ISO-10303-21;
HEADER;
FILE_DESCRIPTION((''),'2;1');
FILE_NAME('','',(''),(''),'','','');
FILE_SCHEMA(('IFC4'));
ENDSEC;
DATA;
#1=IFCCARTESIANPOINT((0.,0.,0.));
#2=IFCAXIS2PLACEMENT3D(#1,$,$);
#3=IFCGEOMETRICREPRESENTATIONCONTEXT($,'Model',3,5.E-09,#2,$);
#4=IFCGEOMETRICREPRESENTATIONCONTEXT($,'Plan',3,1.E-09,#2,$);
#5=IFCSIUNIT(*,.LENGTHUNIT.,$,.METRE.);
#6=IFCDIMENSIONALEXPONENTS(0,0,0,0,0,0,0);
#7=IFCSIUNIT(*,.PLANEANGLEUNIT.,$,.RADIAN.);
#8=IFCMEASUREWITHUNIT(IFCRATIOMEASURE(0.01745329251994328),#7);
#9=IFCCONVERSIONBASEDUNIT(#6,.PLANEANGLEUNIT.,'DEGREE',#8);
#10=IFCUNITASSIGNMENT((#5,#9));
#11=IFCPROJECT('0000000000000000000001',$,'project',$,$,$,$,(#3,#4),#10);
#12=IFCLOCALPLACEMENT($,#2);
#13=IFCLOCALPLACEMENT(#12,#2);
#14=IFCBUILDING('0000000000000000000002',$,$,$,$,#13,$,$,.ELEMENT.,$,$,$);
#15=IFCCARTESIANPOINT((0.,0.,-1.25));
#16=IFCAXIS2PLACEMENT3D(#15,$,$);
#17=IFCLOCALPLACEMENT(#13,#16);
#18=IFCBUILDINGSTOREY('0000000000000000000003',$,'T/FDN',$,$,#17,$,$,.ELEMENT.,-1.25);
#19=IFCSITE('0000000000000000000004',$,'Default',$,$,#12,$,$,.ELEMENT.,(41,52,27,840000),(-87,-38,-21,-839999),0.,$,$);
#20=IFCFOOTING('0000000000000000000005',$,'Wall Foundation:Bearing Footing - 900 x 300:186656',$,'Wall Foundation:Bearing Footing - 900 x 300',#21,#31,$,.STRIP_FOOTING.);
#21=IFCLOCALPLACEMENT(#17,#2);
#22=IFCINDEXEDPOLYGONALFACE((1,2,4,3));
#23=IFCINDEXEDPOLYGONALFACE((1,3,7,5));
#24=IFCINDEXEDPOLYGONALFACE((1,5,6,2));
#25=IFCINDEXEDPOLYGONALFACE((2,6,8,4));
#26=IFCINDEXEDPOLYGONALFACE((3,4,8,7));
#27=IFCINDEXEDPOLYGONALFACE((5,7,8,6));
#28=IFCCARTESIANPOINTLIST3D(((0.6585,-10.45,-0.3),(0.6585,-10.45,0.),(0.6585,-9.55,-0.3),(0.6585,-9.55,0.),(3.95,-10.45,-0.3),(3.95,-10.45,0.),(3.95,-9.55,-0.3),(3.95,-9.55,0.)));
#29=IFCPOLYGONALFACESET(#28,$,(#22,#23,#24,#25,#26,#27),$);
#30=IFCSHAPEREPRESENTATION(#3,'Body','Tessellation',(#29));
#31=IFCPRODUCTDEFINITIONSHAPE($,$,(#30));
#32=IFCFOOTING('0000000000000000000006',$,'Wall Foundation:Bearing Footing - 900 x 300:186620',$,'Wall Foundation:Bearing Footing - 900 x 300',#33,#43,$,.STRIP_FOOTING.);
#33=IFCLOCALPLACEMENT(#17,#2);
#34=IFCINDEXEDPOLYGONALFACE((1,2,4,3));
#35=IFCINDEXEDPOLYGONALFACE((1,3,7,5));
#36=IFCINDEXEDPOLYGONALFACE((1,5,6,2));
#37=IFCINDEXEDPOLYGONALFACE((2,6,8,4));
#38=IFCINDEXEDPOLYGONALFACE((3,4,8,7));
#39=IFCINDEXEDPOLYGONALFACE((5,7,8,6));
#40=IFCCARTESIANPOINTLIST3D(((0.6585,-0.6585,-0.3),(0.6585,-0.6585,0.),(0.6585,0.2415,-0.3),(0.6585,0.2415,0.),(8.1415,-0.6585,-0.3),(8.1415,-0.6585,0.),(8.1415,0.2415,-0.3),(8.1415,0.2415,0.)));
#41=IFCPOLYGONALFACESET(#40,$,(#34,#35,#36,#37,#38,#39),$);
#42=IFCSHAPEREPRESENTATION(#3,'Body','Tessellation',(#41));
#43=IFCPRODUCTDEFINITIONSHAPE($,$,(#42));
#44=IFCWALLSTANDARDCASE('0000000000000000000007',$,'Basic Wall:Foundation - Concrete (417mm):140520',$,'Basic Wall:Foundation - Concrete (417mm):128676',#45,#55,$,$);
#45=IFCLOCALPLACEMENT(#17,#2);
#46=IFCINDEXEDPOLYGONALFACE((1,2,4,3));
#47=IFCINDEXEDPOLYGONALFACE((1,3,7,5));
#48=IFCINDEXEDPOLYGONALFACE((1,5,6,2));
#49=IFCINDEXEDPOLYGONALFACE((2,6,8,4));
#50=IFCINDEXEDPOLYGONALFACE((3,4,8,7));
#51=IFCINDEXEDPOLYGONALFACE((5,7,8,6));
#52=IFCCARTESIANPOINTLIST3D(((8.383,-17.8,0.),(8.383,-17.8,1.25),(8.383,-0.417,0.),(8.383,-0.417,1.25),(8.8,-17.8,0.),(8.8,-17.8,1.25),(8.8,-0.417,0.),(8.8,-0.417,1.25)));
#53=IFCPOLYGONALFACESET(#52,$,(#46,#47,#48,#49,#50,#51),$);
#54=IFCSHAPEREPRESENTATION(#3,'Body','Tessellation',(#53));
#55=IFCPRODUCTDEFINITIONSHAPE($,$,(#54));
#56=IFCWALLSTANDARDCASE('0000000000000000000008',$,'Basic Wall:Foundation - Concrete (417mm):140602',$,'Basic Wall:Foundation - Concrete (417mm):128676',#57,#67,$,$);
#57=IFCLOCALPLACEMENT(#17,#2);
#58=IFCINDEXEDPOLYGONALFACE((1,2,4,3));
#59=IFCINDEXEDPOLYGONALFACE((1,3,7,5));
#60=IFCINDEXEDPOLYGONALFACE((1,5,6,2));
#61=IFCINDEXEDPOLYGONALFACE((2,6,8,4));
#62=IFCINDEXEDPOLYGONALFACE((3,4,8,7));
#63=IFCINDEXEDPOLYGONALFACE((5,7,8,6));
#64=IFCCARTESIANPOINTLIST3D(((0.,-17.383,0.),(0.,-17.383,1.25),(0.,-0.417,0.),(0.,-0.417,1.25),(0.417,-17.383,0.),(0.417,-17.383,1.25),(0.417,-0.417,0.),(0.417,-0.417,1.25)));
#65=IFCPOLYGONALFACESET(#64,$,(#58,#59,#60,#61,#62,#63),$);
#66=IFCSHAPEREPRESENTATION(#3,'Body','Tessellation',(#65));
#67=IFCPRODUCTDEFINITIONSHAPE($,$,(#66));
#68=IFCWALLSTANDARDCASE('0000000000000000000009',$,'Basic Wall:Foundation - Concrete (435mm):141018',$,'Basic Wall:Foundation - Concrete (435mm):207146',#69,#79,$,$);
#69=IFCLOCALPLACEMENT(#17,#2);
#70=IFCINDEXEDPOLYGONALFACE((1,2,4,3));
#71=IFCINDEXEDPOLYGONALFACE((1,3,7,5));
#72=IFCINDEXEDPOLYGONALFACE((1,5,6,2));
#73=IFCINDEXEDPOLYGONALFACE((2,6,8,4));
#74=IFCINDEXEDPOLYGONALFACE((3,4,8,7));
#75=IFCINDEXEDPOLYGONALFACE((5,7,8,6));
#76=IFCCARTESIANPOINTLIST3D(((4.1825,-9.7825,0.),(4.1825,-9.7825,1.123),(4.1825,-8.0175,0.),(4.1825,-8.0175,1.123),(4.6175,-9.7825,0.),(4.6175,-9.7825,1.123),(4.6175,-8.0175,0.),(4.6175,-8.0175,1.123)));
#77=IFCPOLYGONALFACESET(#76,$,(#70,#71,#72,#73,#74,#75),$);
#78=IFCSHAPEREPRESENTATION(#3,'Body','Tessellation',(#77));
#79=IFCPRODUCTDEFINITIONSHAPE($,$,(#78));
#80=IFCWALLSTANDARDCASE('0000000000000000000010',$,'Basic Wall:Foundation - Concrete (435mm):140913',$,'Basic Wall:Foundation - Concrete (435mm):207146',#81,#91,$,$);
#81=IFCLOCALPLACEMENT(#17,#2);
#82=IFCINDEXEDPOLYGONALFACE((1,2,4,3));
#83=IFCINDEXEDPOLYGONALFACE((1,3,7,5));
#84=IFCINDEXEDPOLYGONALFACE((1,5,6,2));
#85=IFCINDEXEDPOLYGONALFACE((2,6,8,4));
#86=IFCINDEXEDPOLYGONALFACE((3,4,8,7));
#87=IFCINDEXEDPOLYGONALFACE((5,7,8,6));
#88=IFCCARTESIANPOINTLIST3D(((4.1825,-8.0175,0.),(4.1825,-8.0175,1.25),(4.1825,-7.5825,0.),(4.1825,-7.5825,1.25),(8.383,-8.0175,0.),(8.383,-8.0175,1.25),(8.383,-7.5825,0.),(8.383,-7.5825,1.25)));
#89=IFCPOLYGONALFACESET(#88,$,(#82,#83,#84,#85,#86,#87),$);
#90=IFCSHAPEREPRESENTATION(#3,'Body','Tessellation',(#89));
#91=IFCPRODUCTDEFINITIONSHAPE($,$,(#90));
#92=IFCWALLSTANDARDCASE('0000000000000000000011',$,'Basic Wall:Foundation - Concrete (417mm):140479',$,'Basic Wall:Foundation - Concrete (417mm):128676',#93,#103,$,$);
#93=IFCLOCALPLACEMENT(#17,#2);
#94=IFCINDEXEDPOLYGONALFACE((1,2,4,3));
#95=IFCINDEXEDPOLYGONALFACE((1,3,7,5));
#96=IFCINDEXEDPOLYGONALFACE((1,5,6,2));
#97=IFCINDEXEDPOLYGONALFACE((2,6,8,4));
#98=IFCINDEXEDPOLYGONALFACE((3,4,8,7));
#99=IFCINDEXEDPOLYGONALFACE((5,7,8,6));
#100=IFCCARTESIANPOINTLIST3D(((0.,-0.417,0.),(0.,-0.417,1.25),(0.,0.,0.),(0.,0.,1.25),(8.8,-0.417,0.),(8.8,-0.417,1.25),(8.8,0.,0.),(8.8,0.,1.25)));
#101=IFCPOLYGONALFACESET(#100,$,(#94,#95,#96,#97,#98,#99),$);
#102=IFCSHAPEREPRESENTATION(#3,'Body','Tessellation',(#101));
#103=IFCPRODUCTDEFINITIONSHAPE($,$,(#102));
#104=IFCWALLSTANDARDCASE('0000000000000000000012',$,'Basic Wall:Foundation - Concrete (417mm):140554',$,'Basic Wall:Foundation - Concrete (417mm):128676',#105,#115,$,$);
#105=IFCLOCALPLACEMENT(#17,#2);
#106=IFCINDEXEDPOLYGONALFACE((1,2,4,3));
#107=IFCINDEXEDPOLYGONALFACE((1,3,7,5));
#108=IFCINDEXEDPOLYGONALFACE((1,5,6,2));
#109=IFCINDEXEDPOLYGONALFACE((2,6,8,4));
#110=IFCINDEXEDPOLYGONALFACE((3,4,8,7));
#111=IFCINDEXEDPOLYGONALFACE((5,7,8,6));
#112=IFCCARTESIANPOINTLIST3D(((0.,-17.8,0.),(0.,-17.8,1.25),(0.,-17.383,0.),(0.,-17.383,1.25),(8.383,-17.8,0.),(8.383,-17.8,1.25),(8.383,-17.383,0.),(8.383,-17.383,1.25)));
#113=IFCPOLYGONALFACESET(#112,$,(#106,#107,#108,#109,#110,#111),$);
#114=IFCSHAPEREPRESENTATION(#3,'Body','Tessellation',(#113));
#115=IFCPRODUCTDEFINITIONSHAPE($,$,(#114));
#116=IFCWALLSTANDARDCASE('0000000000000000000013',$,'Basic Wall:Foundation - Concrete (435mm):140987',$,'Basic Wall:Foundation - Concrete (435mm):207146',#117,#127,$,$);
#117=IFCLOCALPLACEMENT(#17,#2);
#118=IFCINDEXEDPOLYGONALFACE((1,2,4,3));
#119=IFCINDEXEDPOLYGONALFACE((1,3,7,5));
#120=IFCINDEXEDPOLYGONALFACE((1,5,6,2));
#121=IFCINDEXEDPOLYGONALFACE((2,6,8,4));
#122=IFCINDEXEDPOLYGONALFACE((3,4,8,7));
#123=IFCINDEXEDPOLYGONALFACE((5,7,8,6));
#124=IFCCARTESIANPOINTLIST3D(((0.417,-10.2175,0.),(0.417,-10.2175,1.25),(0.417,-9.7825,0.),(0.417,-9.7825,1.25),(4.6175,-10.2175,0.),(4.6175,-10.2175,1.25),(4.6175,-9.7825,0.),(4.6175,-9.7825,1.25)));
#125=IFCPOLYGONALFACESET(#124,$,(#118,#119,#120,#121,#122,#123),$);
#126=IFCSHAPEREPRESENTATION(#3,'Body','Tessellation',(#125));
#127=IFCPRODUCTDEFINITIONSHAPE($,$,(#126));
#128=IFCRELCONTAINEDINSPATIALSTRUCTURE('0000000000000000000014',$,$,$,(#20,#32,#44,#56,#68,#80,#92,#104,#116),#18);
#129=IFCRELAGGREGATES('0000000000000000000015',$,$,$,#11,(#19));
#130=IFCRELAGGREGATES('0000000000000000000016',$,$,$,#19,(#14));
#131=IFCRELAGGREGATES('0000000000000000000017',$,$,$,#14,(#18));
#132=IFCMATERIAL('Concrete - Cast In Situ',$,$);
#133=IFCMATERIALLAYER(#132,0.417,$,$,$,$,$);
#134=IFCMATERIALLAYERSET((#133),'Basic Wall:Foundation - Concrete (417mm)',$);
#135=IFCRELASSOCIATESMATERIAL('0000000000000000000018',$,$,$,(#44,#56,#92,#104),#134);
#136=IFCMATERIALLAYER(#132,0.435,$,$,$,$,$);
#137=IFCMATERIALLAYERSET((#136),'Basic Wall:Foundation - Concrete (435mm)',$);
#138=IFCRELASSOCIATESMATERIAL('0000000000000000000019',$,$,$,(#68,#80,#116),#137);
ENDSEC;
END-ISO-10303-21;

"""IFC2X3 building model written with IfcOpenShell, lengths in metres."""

from ifc_helpers import new_model, entity, si_unit, converted_unit, frame, frame_2d, origin, origin_2d_with_axis, place, context, project, spatial, rectangle, extrude, material, layer, layer_set, layer_usage, element, save


model = new_model("IFC2X3")

# Units and contexts
model_context = context("Model", 3, precision=5e-09, world=origin())
plan_context = context("Plan", 3, precision=1e-09, world=origin())
ifc_project = project(units=[si_unit("LENGTHUNIT", "METRE"), converted_unit("PLANEANGLEUNIT", "DEGREE", entity("IfcRatioMeasure", 0.01745329251994328), si_unit("PLANEANGLEUNIT", "RADIAN"), dimensions=[0, 0, 0, 0, 0, 0, 0])], contexts=[model_context, plan_context])

# Site, building, storey
site_placement = place(None, origin())
site = spatial("IfcSite", under=ifc_project, at=site_placement, Name="Default", CompositionType="ELEMENT", RefLatitude=(41, 52, 27, 840000), RefLongitude=(-87, -38, -21, -839999), RefElevation=0.0)
building_placement = place(site_placement, origin())
building = spatial("IfcBuilding", under=site, at=building_placement, CompositionType="ELEMENT")
storey_placement = place(building_placement, frame((0.0, 0.0, -1.25)))
storey = spatial("IfcBuildingStorey", under=building, at=storey_placement, Name="T/FDN", CompositionType="ELEMENT", Elevation=-1.25)

# Footings
footing_1_placement = place(storey_placement, origin())
element("IfcFooting", 1, at=footing_1_placement, inside=storey, Name="Wall Foundation:Bearing Footing - 900 x 300:186656", ObjectType="Wall Foundation:Bearing Footing - 900 x 300", PredefinedType="STRIP_FOOTING", context=model_context, shape_type="SweptSolid", body=[
    extrude(rectangle(XDim=3.2915, YDim=0.9, at=origin_2d_with_axis()), frame((2.3042, -10.0, -0.3)), (0.0, 0.0, 1.0), 0.3),
])
footing_2_placement = place(storey_placement, origin())
element("IfcFooting", 2, at=footing_2_placement, inside=storey, Name="Wall Foundation:Bearing Footing - 900 x 300:186620", ObjectType="Wall Foundation:Bearing Footing - 900 x 300", PredefinedType="STRIP_FOOTING", context=model_context, shape_type="SweptSolid", body=[
    extrude(rectangle(XDim=7.483, YDim=0.9, at=origin_2d_with_axis()), frame((4.4, -0.2085, -0.3), z_axis=(0.0, 0.0, 1.0), x_axis=(-1.0, 0.0, 0.0)), (0.0, 0.0, 1.0), 0.3),
])

# Walls
ifc_material = material(Name="Concrete - Cast In Situ")
ifc_layer_1 = layer(ifc_material, 0.417)
ifc_layer_set_1 = layer_set([ifc_layer_1], Name="Basic Wall:Foundation - Concrete (417mm)")
ifc_layer_usage_1 = layer_usage(ifc_layer_set_1, "AXIS2", "NEGATIVE", 0.2085)
wall_1_placement = place(storey_placement, frame((8.5915, -0.417, 0.0), z_axis=(0.0, 0.0, 1.0), x_axis=(0.0, -1.0, 0.0)))
element("IfcWallStandardCase", 3, at=wall_1_placement, inside=storey, material=ifc_layer_usage_1, Name="Basic Wall:Foundation - Concrete (417mm):140520", ObjectType="Basic Wall:Foundation - Concrete (417mm):128676", context=model_context, shape_type="SweptSolid", body=[
    extrude(rectangle(XDim=17.383, YDim=0.417, at=frame_2d((8.6915, 0.0), x_axis=(-1.0, 0.0))), origin(), (0.0, 0.0, 1.0), 1.25),
])
wall_2_placement = place(storey_placement, frame((0.2085, -17.383, 0.0), z_axis=(0.0, 0.0, 1.0), x_axis=(0.0, 1.0, 0.0)))
element("IfcWallStandardCase", 4, at=wall_2_placement, inside=storey, material=ifc_layer_usage_1, Name="Basic Wall:Foundation - Concrete (417mm):140602", ObjectType="Basic Wall:Foundation - Concrete (417mm):128676", context=model_context, shape_type="SweptSolid", body=[
    extrude(rectangle(XDim=16.966, YDim=0.417, at=frame_2d((8.483, 0.0), x_axis=(-1.0, 0.0))), origin(), (0.0, 0.0, 1.0), 1.25),
])
ifc_layer_2 = layer(ifc_material, 0.435)
ifc_layer_set_2 = layer_set([ifc_layer_2], Name="Basic Wall:Foundation - Concrete (435mm)")
ifc_layer_usage_2 = layer_usage(ifc_layer_set_2, "AXIS2", "NEGATIVE", 0.2175)
wall_3_placement = place(storey_placement, frame((4.4, -9.7825, 0.0), z_axis=(0.0, 0.0, 1.0), x_axis=(0.0, 1.0, 0.0)))
element("IfcWallStandardCase", 5, at=wall_3_placement, inside=storey, material=ifc_layer_usage_2, Name="Basic Wall:Foundation - Concrete (435mm):141018", ObjectType="Basic Wall:Foundation - Concrete (435mm):207146", context=model_context, shape_type="SweptSolid", body=[
    extrude(rectangle(XDim=1.765, YDim=0.435, at=frame_2d((0.8825, 0.0), x_axis=(-1.0, 0.0))), origin(), (0.0, 0.0, 1.0), 1.123),
])
wall_4_placement = place(storey_placement, frame((8.383, -7.8, 0.0), z_axis=(0.0, 0.0, 1.0), x_axis=(-1.0, 0.0, 0.0)))
element("IfcWallStandardCase", 6, at=wall_4_placement, inside=storey, material=ifc_layer_usage_2, Name="Basic Wall:Foundation - Concrete (435mm):140913", ObjectType="Basic Wall:Foundation - Concrete (435mm):207146", context=model_context, shape_type="SweptSolid", body=[
    extrude(rectangle(XDim=4.2005, YDim=0.435, at=frame_2d((2.1002, 0.0), x_axis=(-1.0, 0.0))), origin(), (0.0, 0.0, 1.0), 1.25),
])
wall_5_placement = place(storey_placement, frame((0.0, -0.2085, 0.0)))
element("IfcWallStandardCase", 7, at=wall_5_placement, inside=storey, material=ifc_layer_usage_1, Name="Basic Wall:Foundation - Concrete (417mm):140479", ObjectType="Basic Wall:Foundation - Concrete (417mm):128676", context=model_context, shape_type="SweptSolid", body=[
    extrude(rectangle(XDim=8.8, YDim=0.417, at=frame_2d((4.4, 0.0), x_axis=(-1.0, 0.0))), origin(), (0.0, 0.0, 1.0), 1.25),
])
wall_6_placement = place(storey_placement, frame((8.383, -17.5915, 0.0), z_axis=(0.0, 0.0, 1.0), x_axis=(-1.0, 0.0, 0.0)))
element("IfcWallStandardCase", 8, at=wall_6_placement, inside=storey, material=ifc_layer_usage_1, Name="Basic Wall:Foundation - Concrete (417mm):140554", ObjectType="Basic Wall:Foundation - Concrete (417mm):128676", context=model_context, shape_type="SweptSolid", body=[
    extrude(rectangle(XDim=8.383, YDim=0.417, at=frame_2d((4.1915, 0.0), x_axis=(-1.0, 0.0))), origin(), (0.0, 0.0, 1.0), 1.25),
])
wall_7_placement = place(storey_placement, frame((0.417, -10.0, 0.0)))
element("IfcWallStandardCase", 9, at=wall_7_placement, inside=storey, material=ifc_layer_usage_2, Name="Basic Wall:Foundation - Concrete (435mm):140987", ObjectType="Basic Wall:Foundation - Concrete (435mm):207146", context=model_context, shape_type="SweptSolid", body=[
    extrude(rectangle(XDim=4.2005, YDim=0.435, at=frame_2d((2.1002, 0.0), x_axis=(-1.0, 0.0))), origin(), (0.0, 0.0, 1.0), 1.25),
])

save(model, "model.ifc")
